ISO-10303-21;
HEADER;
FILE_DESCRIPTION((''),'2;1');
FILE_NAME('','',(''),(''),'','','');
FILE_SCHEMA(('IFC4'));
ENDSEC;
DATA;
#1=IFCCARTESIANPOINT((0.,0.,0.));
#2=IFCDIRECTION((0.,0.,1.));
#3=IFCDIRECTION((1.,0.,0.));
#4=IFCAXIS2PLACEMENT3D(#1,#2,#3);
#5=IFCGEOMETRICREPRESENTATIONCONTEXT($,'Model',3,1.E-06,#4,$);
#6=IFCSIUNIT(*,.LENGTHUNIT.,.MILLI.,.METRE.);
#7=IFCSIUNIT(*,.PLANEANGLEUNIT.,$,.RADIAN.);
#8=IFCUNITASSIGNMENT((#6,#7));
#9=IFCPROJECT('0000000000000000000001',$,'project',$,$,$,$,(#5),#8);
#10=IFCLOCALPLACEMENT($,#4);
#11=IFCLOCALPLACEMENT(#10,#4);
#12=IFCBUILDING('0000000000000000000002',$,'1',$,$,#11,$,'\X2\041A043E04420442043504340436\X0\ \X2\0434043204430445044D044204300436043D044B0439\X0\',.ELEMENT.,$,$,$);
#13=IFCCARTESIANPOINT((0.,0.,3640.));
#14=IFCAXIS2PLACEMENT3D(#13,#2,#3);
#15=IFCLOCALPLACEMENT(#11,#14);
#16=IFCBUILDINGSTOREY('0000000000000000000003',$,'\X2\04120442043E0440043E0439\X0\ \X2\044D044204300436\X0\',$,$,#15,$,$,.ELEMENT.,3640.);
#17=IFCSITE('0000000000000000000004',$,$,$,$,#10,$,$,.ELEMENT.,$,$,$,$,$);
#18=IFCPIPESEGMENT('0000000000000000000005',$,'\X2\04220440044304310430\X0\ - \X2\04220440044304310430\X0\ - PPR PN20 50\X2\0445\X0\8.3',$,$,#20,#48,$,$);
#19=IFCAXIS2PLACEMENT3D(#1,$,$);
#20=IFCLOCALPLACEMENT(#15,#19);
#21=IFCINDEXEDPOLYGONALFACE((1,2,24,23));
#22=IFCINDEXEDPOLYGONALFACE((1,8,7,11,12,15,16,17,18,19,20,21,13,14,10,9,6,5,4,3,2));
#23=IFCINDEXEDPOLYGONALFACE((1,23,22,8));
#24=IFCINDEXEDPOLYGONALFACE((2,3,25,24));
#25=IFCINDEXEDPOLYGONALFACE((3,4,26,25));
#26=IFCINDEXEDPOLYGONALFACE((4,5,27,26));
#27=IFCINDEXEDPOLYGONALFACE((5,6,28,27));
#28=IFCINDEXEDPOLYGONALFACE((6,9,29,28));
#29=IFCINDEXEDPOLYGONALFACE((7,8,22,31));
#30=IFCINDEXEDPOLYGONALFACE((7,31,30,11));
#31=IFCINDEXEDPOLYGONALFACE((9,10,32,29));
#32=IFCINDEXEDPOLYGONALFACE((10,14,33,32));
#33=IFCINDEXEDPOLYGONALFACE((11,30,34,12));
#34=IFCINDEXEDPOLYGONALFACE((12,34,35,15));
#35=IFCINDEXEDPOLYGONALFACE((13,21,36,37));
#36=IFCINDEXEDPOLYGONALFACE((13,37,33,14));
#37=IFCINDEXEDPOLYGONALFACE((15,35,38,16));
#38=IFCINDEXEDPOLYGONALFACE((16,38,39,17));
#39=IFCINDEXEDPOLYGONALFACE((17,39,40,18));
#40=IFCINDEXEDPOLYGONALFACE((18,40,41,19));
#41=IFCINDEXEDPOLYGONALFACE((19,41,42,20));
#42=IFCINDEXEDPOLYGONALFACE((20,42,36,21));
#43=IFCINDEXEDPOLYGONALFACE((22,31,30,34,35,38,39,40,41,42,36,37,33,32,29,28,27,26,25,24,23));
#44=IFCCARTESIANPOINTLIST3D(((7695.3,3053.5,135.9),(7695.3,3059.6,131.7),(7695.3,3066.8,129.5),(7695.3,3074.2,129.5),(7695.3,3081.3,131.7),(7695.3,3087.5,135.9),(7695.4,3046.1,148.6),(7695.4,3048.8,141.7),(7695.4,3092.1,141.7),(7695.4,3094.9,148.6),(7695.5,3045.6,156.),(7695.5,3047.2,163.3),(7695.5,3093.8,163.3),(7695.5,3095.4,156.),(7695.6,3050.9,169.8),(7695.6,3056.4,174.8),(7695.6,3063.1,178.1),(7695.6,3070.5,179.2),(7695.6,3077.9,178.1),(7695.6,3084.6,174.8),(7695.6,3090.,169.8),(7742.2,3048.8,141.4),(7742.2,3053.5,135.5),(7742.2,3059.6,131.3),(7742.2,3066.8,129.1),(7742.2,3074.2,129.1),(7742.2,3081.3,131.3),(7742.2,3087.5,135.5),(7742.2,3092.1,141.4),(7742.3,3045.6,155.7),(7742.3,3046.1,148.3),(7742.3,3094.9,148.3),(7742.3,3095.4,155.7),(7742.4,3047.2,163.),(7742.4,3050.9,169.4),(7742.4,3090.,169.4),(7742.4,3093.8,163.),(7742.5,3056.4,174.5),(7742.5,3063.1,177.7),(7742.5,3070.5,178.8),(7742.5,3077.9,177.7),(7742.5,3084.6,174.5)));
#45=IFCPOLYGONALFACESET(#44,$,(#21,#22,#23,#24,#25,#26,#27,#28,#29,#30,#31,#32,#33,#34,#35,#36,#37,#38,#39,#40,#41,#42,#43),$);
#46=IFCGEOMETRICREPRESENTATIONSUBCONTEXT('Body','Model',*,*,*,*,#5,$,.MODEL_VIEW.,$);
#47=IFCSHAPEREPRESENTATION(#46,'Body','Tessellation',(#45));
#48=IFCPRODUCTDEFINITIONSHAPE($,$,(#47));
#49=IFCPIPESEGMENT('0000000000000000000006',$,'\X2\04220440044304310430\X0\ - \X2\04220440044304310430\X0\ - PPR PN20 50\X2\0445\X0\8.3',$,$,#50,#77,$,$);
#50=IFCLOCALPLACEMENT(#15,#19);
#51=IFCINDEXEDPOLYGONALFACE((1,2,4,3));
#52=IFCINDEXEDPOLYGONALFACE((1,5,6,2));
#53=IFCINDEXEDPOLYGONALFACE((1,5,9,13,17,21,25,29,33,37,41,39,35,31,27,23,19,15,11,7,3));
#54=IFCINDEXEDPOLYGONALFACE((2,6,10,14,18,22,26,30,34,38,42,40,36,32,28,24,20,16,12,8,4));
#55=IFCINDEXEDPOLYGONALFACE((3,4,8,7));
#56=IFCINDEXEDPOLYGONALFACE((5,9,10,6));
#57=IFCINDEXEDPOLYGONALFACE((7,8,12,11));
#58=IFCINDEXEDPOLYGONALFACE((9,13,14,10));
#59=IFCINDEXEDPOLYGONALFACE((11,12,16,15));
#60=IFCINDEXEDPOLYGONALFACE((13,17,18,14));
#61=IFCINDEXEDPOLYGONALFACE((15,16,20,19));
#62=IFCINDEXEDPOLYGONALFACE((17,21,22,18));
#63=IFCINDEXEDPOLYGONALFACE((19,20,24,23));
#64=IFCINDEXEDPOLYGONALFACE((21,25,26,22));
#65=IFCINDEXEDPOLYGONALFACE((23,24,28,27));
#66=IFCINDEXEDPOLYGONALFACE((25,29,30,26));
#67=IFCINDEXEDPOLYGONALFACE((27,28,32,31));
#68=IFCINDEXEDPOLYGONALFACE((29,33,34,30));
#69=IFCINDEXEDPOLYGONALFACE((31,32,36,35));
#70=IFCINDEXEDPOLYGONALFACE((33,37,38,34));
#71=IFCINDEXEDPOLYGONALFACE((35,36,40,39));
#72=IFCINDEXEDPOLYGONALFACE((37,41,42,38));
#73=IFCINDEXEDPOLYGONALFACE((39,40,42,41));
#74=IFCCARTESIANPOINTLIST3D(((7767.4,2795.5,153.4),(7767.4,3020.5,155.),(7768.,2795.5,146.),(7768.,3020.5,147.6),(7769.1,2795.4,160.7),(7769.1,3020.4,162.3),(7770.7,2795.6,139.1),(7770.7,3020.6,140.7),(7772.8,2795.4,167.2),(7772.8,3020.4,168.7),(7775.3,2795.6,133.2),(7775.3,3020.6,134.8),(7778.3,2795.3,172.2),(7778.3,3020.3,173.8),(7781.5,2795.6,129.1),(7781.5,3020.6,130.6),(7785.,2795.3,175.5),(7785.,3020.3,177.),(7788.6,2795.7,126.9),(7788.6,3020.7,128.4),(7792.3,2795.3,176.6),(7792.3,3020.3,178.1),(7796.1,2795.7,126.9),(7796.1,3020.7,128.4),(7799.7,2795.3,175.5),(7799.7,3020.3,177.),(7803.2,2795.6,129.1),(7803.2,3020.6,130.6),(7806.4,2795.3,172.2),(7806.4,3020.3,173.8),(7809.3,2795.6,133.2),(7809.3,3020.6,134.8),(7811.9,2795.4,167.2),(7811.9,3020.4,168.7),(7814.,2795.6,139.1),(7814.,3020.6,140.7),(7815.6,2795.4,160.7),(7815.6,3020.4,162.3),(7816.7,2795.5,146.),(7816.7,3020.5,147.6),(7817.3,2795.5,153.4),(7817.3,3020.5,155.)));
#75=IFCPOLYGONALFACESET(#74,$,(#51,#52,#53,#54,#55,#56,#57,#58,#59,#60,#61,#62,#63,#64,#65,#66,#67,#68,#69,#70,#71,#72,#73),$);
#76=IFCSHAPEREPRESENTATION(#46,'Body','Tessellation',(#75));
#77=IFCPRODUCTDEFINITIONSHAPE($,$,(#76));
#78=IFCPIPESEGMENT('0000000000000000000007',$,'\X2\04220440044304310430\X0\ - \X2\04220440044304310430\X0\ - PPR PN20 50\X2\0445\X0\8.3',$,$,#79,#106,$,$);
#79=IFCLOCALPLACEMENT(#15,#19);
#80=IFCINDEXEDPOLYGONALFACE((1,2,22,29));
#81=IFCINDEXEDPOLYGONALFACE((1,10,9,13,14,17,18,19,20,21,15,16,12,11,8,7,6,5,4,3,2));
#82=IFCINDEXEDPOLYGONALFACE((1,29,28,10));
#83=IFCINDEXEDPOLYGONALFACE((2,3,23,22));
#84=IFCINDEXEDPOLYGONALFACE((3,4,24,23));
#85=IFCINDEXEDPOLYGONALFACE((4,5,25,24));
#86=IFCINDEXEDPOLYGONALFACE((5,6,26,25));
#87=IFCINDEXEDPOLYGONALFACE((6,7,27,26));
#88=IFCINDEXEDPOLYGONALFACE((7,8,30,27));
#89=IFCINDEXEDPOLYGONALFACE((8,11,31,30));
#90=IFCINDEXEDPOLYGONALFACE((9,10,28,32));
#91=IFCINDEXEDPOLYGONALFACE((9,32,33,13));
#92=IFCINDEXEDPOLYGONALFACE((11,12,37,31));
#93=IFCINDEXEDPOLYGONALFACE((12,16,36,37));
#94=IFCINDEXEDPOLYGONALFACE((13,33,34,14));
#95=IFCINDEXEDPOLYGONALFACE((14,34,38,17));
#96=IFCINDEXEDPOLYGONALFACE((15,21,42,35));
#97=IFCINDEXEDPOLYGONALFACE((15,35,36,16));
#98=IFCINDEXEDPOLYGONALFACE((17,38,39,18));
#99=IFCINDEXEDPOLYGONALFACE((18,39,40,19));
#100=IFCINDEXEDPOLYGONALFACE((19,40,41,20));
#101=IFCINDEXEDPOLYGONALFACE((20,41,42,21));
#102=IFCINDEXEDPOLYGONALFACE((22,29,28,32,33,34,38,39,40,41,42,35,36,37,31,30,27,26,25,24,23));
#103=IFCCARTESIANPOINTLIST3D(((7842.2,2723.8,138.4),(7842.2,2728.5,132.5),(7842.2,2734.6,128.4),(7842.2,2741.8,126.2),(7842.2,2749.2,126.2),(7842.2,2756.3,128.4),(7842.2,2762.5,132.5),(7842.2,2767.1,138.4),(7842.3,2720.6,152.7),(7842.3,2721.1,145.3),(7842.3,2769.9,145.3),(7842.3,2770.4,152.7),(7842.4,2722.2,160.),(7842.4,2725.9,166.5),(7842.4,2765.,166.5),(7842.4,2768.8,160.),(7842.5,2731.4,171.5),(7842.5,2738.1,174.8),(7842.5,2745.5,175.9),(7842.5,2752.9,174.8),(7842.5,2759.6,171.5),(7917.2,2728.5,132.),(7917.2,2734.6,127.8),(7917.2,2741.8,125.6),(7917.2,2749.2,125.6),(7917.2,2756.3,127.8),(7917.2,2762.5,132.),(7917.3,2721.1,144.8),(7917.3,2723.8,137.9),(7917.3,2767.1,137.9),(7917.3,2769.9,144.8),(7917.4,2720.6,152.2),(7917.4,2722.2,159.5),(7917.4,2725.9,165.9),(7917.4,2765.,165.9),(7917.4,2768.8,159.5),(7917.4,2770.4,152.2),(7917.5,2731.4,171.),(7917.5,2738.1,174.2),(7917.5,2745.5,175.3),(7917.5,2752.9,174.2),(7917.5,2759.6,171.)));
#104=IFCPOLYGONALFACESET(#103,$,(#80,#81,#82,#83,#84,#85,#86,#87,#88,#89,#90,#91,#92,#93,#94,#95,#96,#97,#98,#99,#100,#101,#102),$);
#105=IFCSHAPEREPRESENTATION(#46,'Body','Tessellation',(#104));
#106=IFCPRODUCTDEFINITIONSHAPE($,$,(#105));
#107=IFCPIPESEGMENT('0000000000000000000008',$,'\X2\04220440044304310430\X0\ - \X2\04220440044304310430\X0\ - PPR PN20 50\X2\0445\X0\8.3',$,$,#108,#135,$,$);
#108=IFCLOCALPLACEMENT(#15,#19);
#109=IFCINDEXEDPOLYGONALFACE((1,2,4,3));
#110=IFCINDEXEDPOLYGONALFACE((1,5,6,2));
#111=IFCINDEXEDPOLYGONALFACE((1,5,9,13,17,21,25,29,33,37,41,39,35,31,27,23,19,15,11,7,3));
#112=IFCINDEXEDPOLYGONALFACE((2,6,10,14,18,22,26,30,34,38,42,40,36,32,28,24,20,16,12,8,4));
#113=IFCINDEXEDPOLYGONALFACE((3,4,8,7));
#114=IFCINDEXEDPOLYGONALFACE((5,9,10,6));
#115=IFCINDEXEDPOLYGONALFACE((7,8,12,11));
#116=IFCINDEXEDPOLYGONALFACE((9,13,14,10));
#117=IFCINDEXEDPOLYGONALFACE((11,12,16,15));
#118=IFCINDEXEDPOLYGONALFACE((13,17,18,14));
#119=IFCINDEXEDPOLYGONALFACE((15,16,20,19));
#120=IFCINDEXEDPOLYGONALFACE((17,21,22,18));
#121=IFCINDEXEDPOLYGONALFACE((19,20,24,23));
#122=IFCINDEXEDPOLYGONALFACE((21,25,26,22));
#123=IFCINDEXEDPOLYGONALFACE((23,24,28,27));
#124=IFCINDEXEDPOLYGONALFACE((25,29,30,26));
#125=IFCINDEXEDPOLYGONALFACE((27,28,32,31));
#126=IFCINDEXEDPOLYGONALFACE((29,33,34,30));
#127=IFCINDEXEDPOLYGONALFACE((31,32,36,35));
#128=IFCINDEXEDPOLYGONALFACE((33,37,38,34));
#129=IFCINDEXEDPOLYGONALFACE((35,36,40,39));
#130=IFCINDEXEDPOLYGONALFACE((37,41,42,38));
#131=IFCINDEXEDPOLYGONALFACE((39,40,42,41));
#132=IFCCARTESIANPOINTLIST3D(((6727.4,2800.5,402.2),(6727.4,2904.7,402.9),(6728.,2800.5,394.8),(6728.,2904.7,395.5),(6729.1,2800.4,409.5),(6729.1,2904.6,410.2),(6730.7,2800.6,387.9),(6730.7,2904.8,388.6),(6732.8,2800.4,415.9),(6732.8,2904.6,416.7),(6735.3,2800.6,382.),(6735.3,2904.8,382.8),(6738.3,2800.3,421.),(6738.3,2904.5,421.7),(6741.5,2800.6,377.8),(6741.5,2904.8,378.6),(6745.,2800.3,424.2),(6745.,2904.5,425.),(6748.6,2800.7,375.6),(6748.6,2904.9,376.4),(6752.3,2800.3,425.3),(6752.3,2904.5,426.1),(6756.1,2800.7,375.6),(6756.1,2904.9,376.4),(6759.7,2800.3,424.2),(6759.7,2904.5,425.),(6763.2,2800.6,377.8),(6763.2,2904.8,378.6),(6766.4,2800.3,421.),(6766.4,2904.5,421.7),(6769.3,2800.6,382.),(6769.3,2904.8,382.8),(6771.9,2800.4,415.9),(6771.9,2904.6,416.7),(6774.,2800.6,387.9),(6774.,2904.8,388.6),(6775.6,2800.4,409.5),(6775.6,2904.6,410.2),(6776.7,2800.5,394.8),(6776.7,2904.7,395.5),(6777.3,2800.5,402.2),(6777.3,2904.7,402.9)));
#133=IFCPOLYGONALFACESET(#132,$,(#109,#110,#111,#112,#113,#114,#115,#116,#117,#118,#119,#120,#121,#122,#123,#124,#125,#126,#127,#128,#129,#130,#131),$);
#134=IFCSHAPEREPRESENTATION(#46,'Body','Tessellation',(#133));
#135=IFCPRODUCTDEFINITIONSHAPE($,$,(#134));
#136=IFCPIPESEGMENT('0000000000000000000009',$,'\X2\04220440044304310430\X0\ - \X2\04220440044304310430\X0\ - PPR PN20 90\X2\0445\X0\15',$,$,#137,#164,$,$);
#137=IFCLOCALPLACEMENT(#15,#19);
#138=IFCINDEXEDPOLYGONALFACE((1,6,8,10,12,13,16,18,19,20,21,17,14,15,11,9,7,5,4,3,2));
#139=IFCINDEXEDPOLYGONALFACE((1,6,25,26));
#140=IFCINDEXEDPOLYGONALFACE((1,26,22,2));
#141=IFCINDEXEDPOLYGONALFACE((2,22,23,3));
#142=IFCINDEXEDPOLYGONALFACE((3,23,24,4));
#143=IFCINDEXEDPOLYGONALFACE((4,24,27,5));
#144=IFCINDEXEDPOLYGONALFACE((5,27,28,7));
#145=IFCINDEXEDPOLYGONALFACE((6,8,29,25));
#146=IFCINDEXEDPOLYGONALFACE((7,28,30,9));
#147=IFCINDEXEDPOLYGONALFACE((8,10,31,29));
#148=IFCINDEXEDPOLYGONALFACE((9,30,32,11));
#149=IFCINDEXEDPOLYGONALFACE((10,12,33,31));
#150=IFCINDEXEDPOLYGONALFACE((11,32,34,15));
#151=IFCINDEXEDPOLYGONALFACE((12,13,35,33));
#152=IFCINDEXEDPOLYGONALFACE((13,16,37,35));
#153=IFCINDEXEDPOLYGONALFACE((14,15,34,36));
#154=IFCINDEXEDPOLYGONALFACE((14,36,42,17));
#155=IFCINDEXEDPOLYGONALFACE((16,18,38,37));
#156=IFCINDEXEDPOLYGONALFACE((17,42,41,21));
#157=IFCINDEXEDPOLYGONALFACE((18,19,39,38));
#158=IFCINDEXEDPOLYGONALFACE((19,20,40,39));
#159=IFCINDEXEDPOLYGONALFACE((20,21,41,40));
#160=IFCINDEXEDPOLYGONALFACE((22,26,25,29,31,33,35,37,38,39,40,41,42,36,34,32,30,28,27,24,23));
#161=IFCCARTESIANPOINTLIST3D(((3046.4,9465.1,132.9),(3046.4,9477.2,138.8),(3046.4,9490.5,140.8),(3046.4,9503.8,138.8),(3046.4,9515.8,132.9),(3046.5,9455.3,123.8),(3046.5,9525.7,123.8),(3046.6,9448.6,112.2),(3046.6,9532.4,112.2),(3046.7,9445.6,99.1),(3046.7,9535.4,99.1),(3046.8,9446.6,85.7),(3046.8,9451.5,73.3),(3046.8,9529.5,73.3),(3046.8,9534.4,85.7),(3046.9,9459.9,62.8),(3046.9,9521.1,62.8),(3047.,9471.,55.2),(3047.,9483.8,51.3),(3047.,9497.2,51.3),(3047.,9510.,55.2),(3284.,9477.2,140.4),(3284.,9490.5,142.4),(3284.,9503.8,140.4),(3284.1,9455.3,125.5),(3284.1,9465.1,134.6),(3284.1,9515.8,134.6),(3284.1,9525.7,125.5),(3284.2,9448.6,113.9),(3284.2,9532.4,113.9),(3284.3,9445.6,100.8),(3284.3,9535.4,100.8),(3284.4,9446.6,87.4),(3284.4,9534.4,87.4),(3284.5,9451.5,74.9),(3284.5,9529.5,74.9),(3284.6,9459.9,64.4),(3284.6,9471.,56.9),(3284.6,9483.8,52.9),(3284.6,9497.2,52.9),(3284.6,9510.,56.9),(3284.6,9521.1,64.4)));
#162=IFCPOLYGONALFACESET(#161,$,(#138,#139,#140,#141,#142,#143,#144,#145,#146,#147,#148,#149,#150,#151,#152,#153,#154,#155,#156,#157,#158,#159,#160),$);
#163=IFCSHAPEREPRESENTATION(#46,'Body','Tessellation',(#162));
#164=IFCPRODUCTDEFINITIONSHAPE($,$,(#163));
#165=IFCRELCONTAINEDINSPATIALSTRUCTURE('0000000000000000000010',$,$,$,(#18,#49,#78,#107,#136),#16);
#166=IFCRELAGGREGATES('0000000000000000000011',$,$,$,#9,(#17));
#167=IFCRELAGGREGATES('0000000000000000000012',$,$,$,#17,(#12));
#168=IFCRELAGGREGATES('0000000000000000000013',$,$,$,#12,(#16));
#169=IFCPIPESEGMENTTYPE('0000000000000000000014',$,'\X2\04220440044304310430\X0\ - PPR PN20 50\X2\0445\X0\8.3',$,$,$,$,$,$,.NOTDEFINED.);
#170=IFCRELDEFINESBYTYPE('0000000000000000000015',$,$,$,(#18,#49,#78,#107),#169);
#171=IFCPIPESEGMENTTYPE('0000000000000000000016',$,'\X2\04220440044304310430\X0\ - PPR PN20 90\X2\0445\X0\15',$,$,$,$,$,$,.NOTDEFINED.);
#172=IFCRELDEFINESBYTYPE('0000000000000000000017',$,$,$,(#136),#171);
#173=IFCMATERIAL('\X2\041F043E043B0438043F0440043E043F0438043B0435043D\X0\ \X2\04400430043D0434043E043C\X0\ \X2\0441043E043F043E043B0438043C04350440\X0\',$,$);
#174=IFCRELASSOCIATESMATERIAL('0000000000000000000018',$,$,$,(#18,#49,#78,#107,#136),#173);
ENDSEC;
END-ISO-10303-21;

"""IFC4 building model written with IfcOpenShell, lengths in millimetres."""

from ifc_helpers import new_model, entity, si_unit, frame, origin_with_axes, place, context, subcontext, project, spatial, source, transform, mapped, material, type_object, element, save


model = new_model("IFC4")

# Units and contexts
model_context = context("Model", 3, precision=1e-06, world=origin_with_axes())
body_context = subcontext(model_context, "Body", "Model", "MODEL_VIEW")
ifc_project = project(units=[si_unit("LENGTHUNIT", "METRE", prefix="MILLI"), si_unit("PLANEANGLEUNIT", "RADIAN")], contexts=[model_context])

# Site, building, storey
site_placement = place(None, origin_with_axes())
site = spatial("IfcSite", under=ifc_project, at=site_placement, CompositionType="ELEMENT")
building_placement = place(site_placement, origin_with_axes())
building = spatial("IfcBuilding", under=site, at=building_placement, Name="1", LongName="Коттедж двухэтажный", CompositionType="ELEMENT")
storey_placement = place(building_placement, frame((0.0, 0.0, 3640.0), z_axis=(0.0, 0.0, 1.0), x_axis=(1.0, 0.0, 0.0)))
storey = spatial("IfcBuildingStorey", under=building, at=storey_placement, Name="Второй этаж", CompositionType="ELEMENT", Elevation=3640.0)

# Pipe segments
ifc_material = material(Name="Полипропилен рандом сополимер")
pipe_segment_type_1 = type_object("IfcPipeSegmentType", Name="Труба - PPR PN20 50х8.3", PredefinedType="NOTDEFINED")
pipe_segment_type_2 = type_object("IfcPipeSegmentType", Name="Труба - PPR PN20 90х15", PredefinedType="NOTDEFINED")
shared_shape_1 = source(origin_with_axes(), body_context, "Body", "AdvancedSweptSolid", [
    entity("IfcSweptDiskSolid", entity("IfcIndexedPolyCurve", entity("IfcCartesianPointList3D", [[0.0, 0.0, 0.0], [46.9, 0.0, 0.3]]), [entity("IfcLineIndex", [1, 2])]), 25.0),
])
pipe_segment_1_placement = place(storey_placement, frame((7742.3, 3070.5, 153.8), z_axis=(0.0, 0.0, 1.0), x_axis=(-1.0, 0.0, 0.0)))
element("IfcPipeSegment", 1, at=pipe_segment_1_placement, inside=storey, type_object=pipe_segment_type_1, material=ifc_material, Name="Труба - Труба - PPR PN20 50х8.3", context=body_context, shape_type="MappedRepresentation", body=[
    mapped(shared_shape_1, transform((0.0, 0.0, 0.0), x_axis=(1.0, 0.0, 0.0), y_axis=(0.0, 1.0, 0.0), z_axis=(0.0, 0.0, 1.0), scale=1.0)),
])
shared_shape_2 = source(origin_with_axes(), body_context, "Body", "AdvancedSweptSolid", [
    entity("IfcSweptDiskSolid", entity("IfcIndexedPolyCurve", entity("IfcCartesianPointList3D", [[0.0, 0.0, 0.0], [225.0, 0.0, 1.6]]), [entity("IfcLineIndex", [1, 2])]), 25.0),
])
pipe_segment_2_placement = place(storey_placement, frame((7792.3, 2795.5, 151.6), z_axis=(0.0, 0.0, 1.0), x_axis=(0.0, 1.0, 0.0)))
element("IfcPipeSegment", 2, at=pipe_segment_2_placement, inside=storey, type_object=pipe_segment_type_1, material=ifc_material, Name="Труба - Труба - PPR PN20 50х8.3", context=body_context, shape_type="MappedRepresentation", body=[
    mapped(shared_shape_2, transform((0.0, 0.0, 0.0), x_axis=(1.0, 0.0, 0.0), y_axis=(0.0, 1.0, 0.0), z_axis=(0.0, 0.0, 1.0), scale=1.0)),
])
shared_shape_3 = source(origin_with_axes(), body_context, "Body", "AdvancedSweptSolid", [
    entity("IfcSweptDiskSolid", entity("IfcIndexedPolyCurve", entity("IfcCartesianPointList3D", [[0.0, 0.0, 0.0], [75.0, 0.0, 0.5]]), [entity("IfcLineIndex", [1, 2])]), 25.0),
])
pipe_segment_3_placement = place(storey_placement, frame((7917.3, 2745.5, 150.3), z_axis=(0.0, 0.0, 1.0), x_axis=(-1.0, 0.0, 0.0)))
element("IfcPipeSegment", 3, at=pipe_segment_3_placement, inside=storey, type_object=pipe_segment_type_1, material=ifc_material, Name="Труба - Труба - PPR PN20 50х8.3", context=body_context, shape_type="MappedRepresentation", body=[
    mapped(shared_shape_3, transform((0.0, 0.0, 0.0), x_axis=(1.0, 0.0, 0.0), y_axis=(0.0, 1.0, 0.0), z_axis=(0.0, 0.0, 1.0), scale=1.0)),
])
shared_shape_4 = source(origin_with_axes(), body_context, "Body", "AdvancedSweptSolid", [
    entity("IfcSweptDiskSolid", entity("IfcIndexedPolyCurve", entity("IfcCartesianPointList3D", [[0.0, 0.0, 0.0], [104.2, 0.0, 0.7]]), [entity("IfcLineIndex", [1, 2])]), 25.0),
])
pipe_segment_4_placement = place(storey_placement, frame((6752.3, 2800.5, 400.4), z_axis=(0.0, 0.0, 1.0), x_axis=(0.0, 1.0, 0.0)))
element("IfcPipeSegment", 4, at=pipe_segment_4_placement, inside=storey, type_object=pipe_segment_type_1, material=ifc_material, Name="Труба - Труба - PPR PN20 50х8.3", context=body_context, shape_type="MappedRepresentation", body=[
    mapped(shared_shape_4, transform((0.0, 0.0, 0.0), x_axis=(1.0, 0.0, 0.0), y_axis=(0.0, 1.0, 0.0), z_axis=(0.0, 0.0, 1.0), scale=1.0)),
])
shared_shape_5 = source(origin_with_axes(), body_context, "Body", "AdvancedSweptSolid", [
    entity("IfcSweptDiskSolid", entity("IfcIndexedPolyCurve", entity("IfcCartesianPointList3D", [[0.0, 0.0, 0.0], [237.6, 0.0, 1.7]]), [entity("IfcLineIndex", [1, 2])]), 45.0),
])
pipe_segment_5_placement = place(storey_placement, frame((3046.7, 9490.5, 95.8), z_axis=(0.0, 0.0, 1.0), x_axis=(1.0, 0.0, 0.0)))
element("IfcPipeSegment", 5, at=pipe_segment_5_placement, inside=storey, type_object=pipe_segment_type_2, material=ifc_material, Name="Труба - Труба - PPR PN20 90х15", context=body_context, shape_type="MappedRepresentation", body=[
    mapped(shared_shape_5, transform((0.0, 0.0, 0.0), x_axis=(1.0, 0.0, 0.0), y_axis=(0.0, 1.0, 0.0), z_axis=(0.0, 0.0, 1.0), scale=1.0)),
])

save(model, "model.ifc")
